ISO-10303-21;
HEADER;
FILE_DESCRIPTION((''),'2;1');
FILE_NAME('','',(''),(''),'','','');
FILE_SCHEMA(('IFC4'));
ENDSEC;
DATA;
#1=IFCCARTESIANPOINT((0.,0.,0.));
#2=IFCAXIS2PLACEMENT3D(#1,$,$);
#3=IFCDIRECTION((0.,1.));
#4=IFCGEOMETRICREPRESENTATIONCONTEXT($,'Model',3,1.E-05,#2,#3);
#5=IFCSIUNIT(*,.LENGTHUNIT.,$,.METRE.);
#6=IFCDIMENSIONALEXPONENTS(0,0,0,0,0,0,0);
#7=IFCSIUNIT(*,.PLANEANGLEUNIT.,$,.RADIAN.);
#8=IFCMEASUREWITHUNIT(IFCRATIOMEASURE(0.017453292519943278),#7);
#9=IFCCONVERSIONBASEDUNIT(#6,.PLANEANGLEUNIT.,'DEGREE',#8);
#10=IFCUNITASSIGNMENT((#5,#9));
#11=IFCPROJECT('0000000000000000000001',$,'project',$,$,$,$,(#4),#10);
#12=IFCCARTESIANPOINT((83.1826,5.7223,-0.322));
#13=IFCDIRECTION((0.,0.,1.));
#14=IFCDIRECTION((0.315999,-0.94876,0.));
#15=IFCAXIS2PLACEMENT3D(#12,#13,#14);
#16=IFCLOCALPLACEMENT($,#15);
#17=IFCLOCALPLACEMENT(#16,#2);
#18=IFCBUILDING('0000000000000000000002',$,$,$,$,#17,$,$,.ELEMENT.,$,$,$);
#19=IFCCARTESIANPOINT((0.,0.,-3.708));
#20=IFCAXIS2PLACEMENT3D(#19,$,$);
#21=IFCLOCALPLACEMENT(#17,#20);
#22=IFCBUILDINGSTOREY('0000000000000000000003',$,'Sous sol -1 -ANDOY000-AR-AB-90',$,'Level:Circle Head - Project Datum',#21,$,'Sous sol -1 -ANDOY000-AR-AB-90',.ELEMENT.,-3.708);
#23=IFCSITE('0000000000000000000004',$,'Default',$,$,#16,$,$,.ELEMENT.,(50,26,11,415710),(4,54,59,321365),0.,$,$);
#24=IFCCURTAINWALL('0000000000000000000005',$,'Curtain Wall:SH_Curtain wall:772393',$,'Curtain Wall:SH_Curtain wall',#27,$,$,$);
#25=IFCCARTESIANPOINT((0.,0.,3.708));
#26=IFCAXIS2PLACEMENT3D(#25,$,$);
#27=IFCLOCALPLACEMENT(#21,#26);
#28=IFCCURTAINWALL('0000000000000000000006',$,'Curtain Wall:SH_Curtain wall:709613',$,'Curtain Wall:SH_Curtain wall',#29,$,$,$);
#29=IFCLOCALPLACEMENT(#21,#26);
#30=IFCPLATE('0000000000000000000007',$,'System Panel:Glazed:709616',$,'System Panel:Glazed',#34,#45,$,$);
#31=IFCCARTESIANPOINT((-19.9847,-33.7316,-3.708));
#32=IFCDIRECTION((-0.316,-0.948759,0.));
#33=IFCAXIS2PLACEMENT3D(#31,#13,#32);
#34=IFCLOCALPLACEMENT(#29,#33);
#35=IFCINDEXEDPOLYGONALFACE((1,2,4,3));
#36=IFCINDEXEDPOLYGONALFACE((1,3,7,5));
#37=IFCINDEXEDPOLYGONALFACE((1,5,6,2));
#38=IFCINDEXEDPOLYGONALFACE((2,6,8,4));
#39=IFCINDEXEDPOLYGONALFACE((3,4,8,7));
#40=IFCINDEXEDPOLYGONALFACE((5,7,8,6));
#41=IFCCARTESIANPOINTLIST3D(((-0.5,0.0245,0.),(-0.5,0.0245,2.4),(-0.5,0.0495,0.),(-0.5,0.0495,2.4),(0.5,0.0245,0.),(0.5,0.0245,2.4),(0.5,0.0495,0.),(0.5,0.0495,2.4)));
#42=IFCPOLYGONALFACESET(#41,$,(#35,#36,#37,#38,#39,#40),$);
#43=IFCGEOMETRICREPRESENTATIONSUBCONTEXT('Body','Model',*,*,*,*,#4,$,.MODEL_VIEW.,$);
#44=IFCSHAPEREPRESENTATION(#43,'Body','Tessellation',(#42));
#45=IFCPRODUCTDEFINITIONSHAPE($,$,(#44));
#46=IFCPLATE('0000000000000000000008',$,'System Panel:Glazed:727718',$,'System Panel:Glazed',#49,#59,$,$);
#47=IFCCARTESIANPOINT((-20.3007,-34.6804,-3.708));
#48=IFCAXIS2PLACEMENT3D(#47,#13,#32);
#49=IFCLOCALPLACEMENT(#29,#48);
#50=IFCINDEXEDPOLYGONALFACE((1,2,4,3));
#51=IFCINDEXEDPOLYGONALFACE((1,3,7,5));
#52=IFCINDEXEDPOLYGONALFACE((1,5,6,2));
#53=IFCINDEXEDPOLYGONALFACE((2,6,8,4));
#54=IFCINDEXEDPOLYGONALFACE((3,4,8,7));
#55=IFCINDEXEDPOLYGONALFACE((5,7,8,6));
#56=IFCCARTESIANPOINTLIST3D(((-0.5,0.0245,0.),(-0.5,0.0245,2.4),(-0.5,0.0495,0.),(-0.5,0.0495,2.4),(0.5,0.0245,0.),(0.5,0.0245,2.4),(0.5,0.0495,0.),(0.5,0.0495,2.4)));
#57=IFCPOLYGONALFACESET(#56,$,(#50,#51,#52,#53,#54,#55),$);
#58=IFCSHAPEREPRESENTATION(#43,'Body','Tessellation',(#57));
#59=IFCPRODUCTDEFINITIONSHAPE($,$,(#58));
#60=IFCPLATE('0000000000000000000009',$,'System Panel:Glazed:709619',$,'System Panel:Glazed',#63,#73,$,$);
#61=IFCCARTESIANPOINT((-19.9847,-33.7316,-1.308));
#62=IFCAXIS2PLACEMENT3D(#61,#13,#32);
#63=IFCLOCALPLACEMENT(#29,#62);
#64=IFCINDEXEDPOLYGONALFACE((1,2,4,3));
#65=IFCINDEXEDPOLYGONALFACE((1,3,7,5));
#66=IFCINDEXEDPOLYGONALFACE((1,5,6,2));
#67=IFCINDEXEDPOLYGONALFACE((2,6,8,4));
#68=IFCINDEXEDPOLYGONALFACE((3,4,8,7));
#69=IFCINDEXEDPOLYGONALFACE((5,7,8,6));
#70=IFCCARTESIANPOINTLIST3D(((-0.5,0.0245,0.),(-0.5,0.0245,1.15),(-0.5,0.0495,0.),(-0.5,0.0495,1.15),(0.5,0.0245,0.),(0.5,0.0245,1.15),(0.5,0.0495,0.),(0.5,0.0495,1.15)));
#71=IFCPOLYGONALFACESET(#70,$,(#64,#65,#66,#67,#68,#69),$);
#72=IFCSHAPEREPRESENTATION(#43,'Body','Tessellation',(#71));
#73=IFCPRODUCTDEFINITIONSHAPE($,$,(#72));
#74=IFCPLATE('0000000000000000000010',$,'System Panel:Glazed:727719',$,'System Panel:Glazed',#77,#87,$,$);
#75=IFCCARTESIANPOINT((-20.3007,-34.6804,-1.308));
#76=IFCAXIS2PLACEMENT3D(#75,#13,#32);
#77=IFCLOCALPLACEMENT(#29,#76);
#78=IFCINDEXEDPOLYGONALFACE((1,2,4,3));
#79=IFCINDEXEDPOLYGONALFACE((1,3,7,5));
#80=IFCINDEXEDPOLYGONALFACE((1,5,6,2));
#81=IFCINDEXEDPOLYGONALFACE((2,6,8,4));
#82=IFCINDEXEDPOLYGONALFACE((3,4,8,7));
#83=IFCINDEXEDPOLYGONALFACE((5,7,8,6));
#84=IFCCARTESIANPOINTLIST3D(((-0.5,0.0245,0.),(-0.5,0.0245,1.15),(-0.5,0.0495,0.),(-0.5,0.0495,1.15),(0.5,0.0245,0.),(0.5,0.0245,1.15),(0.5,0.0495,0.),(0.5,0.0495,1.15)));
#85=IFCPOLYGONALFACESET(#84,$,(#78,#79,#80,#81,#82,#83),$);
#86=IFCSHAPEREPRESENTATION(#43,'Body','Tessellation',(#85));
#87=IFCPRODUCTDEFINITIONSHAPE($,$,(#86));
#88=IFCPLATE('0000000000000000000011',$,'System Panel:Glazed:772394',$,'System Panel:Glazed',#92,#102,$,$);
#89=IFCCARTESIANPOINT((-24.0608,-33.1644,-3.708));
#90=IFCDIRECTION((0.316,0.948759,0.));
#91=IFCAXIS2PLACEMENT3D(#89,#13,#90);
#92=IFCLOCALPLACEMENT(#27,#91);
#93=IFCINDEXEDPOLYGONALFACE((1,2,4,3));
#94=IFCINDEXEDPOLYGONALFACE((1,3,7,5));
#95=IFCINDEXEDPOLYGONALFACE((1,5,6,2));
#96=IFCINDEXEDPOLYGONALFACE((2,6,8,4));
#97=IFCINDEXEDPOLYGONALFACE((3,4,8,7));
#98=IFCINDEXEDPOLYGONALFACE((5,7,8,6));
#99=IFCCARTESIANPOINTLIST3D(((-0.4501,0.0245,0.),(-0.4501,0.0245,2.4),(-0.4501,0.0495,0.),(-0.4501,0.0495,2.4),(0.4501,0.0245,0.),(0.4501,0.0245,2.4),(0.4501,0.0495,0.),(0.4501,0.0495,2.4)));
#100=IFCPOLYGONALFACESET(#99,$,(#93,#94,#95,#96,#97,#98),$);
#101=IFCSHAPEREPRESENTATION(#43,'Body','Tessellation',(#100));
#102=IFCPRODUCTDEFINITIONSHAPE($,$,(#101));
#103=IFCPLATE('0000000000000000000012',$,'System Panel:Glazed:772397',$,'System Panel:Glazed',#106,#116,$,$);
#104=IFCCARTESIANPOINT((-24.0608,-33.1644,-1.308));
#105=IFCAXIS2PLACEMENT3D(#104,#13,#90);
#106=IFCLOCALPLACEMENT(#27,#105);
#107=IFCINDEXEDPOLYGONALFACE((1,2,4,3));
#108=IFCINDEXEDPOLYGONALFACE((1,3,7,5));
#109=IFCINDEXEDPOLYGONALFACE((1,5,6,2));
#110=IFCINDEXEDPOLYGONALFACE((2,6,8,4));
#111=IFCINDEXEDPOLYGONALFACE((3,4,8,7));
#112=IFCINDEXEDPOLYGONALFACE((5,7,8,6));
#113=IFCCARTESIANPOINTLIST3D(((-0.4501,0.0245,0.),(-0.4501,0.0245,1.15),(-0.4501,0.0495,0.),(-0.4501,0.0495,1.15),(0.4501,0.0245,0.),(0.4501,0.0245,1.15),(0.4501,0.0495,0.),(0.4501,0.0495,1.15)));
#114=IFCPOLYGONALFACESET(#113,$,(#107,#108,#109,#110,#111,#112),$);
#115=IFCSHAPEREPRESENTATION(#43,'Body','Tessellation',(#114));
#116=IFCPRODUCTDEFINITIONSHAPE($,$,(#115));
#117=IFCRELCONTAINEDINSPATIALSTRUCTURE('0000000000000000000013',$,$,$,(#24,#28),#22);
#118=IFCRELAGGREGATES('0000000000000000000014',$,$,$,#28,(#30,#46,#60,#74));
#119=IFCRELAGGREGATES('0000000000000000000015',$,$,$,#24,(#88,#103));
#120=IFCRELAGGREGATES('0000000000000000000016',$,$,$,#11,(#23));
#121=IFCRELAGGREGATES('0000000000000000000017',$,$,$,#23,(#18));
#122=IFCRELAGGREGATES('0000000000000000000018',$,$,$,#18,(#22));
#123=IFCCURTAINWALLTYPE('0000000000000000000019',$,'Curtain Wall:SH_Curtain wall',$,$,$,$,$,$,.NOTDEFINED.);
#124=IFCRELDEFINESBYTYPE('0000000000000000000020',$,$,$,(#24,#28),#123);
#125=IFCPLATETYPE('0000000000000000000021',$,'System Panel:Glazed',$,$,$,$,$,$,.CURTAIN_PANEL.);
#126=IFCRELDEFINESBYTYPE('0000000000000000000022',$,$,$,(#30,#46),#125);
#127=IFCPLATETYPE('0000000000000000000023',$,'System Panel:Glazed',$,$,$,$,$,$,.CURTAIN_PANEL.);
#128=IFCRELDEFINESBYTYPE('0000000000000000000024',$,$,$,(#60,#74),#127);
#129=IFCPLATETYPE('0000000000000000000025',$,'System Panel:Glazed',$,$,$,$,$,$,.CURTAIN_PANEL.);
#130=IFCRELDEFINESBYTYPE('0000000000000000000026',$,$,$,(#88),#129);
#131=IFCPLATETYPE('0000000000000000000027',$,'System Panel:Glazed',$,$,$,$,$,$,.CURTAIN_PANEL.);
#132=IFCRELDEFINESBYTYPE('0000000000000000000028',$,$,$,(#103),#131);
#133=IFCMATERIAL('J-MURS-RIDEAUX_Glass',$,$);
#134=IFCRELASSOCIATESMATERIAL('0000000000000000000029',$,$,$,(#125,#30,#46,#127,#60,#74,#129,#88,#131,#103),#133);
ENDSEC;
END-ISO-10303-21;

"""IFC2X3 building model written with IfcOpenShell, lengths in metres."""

from ifc_helpers import new_model, entity, si_unit, converted_unit, direction, frame, frame_2d, origin, origin_2d_with_axis, place, context, subcontext, project, spatial, rectangle, extrude, source, transform, mapped, material, type_object, type_shapes, element, aggregate, save


model = new_model("IFC2X3")

# Units and contexts
model_context = context("Model", 3, precision=1e-05, world=origin(), true_north=direction((0.0, 1.0)))
body_context = subcontext(model_context, "Body", "Model", "MODEL_VIEW")
ifc_project = project(units=[si_unit("LENGTHUNIT", "METRE"), converted_unit("PLANEANGLEUNIT", "DEGREE", entity("IfcRatioMeasure", 0.017453292519943278), si_unit("PLANEANGLEUNIT", "RADIAN"), dimensions=[0, 0, 0, 0, 0, 0, 0])], contexts=[model_context])

# Site, building, storey
site_placement = place(None, frame((83.1826, 5.7223, -0.322), z_axis=(0.0, 0.0, 1.0), x_axis=(0.315999, -0.94876, 0.0)))
site = spatial("IfcSite", under=ifc_project, at=site_placement, Name="Default", CompositionType="ELEMENT", RefLatitude=(50, 26, 11, 415710), RefLongitude=(4, 54, 59, 321365), RefElevation=0.0)
building_placement = place(site_placement, origin())
building = spatial("IfcBuilding", under=site, at=building_placement, CompositionType="ELEMENT")
storey_placement = place(building_placement, frame((0.0, 0.0, -3.708)))
storey = spatial("IfcBuildingStorey", under=building, at=storey_placement, Name="Sous sol -1 -ANDOY000-AR-AB-90", ObjectType="Level:Circle Head - Project Datum", LongName="Sous sol -1 -ANDOY000-AR-AB-90", CompositionType="ELEMENT", Elevation=-3.708)

# Curtain wall
curtain_wall_type = type_object("IfcCurtainWallType", Name="Curtain Wall:SH_Curtain wall", PredefinedType="NOTDEFINED")
curtain_wall_1_placement = place(storey_placement, frame((0.0, 0.0, 3.708)))
curtain_wall_1 = element("IfcCurtainWall", 1, at=curtain_wall_1_placement, inside=storey, type_object=curtain_wall_type, Name="Curtain Wall:SH_Curtain wall:772393", ObjectType="Curtain Wall:SH_Curtain wall")

# Curtain wall
curtain_wall_2_placement = place(storey_placement, frame((0.0, 0.0, 3.708)))
curtain_wall_2 = element("IfcCurtainWall", 2, at=curtain_wall_2_placement, inside=storey, type_object=curtain_wall_type, Name="Curtain Wall:SH_Curtain wall:709613", ObjectType="Curtain Wall:SH_Curtain wall")

# Plates
ifc_material_1 = material(Name="J-MURS-RIDEAUX_Glass")
plate_type_1 = type_object("IfcPlateType", Name="System Panel:Glazed", PredefinedType="CURTAIN_PANEL", material=ifc_material_1)
shared_shape_1 = source(origin(), body_context, "Body", "SweptSolid", [
    extrude(rectangle(XDim=0.025, YDim=1.0, at=frame_2d((0.0, 0.0), x_axis=(1.0, 0.0))), frame((0.0, 0.037, 0.0), z_axis=(0.0, 0.0, 1.0), x_axis=(0.0, 1.0, 0.0)), (0.0, 0.0, 1.0), 2.4),
])
type_shapes(plate_type_1, [shared_shape_1])
plate_1_placement = place(curtain_wall_2_placement, frame((-19.9847, -33.7316, -3.708), z_axis=(0.0, 0.0, 1.0), x_axis=(-0.316, -0.948759, 0.0)))
plate_1 = element("IfcPlate", 3, at=plate_1_placement, type_object=plate_type_1, material=ifc_material_1, Name="System Panel:Glazed:709616", ObjectType="System Panel:Glazed", context=body_context, shape_type="MappedRepresentation", body=[
    mapped(shared_shape_1, transform((0.0, 0.0, 0.0), scale=1.0)),
])
plate_2_placement = place(curtain_wall_2_placement, frame((-20.3007, -34.6804, -3.708), z_axis=(0.0, 0.0, 1.0), x_axis=(-0.316, -0.948759, 0.0)))
plate_2 = element("IfcPlate", 4, at=plate_2_placement, type_object=plate_type_1, material=ifc_material_1, Name="System Panel:Glazed:727718", ObjectType="System Panel:Glazed", context=body_context, shape_type="MappedRepresentation", body=[
    mapped(shared_shape_1, transform((0.0, 0.0, 0.0), scale=1.0)),
])
plate_type_2 = type_object("IfcPlateType", Name="System Panel:Glazed", PredefinedType="CURTAIN_PANEL", material=ifc_material_1)
shared_shape_2 = source(origin(), body_context, "Body", "SweptSolid", [
    extrude(rectangle(XDim=0.025, YDim=1.0, at=origin_2d_with_axis()), frame((0.0, 0.037, 0.0), z_axis=(0.0, 0.0, 1.0), x_axis=(0.0, 1.0, 0.0)), (0.0, 0.0, 1.0), 1.15),
])
type_shapes(plate_type_2, [shared_shape_2])
plate_3_placement = place(curtain_wall_2_placement, frame((-19.9847, -33.7316, -1.308), z_axis=(0.0, 0.0, 1.0), x_axis=(-0.316, -0.948759, 0.0)))
plate_3 = element("IfcPlate", 5, at=plate_3_placement, type_object=plate_type_2, material=ifc_material_1, Name="System Panel:Glazed:709619", ObjectType="System Panel:Glazed", context=body_context, shape_type="MappedRepresentation", body=[
    mapped(shared_shape_2, transform((0.0, 0.0, 0.0), scale=1.0)),
])
plate_4_placement = place(curtain_wall_2_placement, frame((-20.3007, -34.6804, -1.308), z_axis=(0.0, 0.0, 1.0), x_axis=(-0.316, -0.948759, 0.0)))
plate_4 = element("IfcPlate", 6, at=plate_4_placement, type_object=plate_type_2, material=ifc_material_1, Name="System Panel:Glazed:727719", ObjectType="System Panel:Glazed", context=body_context, shape_type="MappedRepresentation", body=[
    mapped(shared_shape_2, transform((0.0, 0.0, 0.0), scale=1.0)),
])
aggregate(curtain_wall_2, [plate_1, plate_2, plate_3, plate_4])
plate_type_3 = type_object("IfcPlateType", Name="System Panel:Glazed", PredefinedType="CURTAIN_PANEL", material=ifc_material_1)
shared_shape_3 = source(origin(), body_context, "Body", "SweptSolid", [
    extrude(rectangle(XDim=0.025, YDim=0.9002, at=frame_2d((0.0, 0.0), x_axis=(1.0, 0.0))), frame((0.0, 0.037, 0.0), z_axis=(0.0, 0.0, 1.0), x_axis=(0.0, 1.0, 0.0)), (0.0, 0.0, 1.0), 2.4),
])
type_shapes(plate_type_3, [shared_shape_3])
plate_5_placement = place(curtain_wall_1_placement, frame((-24.0608, -33.1644, -3.708), z_axis=(0.0, 0.0, 1.0), x_axis=(0.316, 0.948759, 0.0)))
plate_5 = element("IfcPlate", 7, at=plate_5_placement, type_object=plate_type_3, material=ifc_material_1, Name="System Panel:Glazed:772394", ObjectType="System Panel:Glazed", context=body_context, shape_type="MappedRepresentation", body=[
    mapped(shared_shape_3, transform((0.0, 0.0, 0.0), scale=1.0)),
])
plate_type_4 = type_object("IfcPlateType", Name="System Panel:Glazed", PredefinedType="CURTAIN_PANEL", material=ifc_material_1)
shared_shape_4 = source(origin(), body_context, "Body", "SweptSolid", [
    extrude(rectangle(XDim=0.025, YDim=0.9002, at=frame_2d((0.0, 0.0), x_axis=(1.0, 0.0))), frame((0.0, 0.037, 0.0), z_axis=(0.0, 0.0, 1.0), x_axis=(0.0, 1.0, 0.0)), (0.0, 0.0, 1.0), 1.15),
])
type_shapes(plate_type_4, [shared_shape_4])
plate_6_placement = place(curtain_wall_1_placement, frame((-24.0608, -33.1644, -1.308), z_axis=(0.0, 0.0, 1.0), x_axis=(0.316, 0.948759, 0.0)))
plate_6 = element("IfcPlate", 8, at=plate_6_placement, type_object=plate_type_4, material=ifc_material_1, Name="System Panel:Glazed:772397", ObjectType="System Panel:Glazed", context=body_context, shape_type="MappedRepresentation", body=[
    mapped(shared_shape_4, transform((0.0, 0.0, 0.0), scale=1.0)),
])
aggregate(curtain_wall_1, [plate_5, plate_6])

save(model, "model.ifc")
